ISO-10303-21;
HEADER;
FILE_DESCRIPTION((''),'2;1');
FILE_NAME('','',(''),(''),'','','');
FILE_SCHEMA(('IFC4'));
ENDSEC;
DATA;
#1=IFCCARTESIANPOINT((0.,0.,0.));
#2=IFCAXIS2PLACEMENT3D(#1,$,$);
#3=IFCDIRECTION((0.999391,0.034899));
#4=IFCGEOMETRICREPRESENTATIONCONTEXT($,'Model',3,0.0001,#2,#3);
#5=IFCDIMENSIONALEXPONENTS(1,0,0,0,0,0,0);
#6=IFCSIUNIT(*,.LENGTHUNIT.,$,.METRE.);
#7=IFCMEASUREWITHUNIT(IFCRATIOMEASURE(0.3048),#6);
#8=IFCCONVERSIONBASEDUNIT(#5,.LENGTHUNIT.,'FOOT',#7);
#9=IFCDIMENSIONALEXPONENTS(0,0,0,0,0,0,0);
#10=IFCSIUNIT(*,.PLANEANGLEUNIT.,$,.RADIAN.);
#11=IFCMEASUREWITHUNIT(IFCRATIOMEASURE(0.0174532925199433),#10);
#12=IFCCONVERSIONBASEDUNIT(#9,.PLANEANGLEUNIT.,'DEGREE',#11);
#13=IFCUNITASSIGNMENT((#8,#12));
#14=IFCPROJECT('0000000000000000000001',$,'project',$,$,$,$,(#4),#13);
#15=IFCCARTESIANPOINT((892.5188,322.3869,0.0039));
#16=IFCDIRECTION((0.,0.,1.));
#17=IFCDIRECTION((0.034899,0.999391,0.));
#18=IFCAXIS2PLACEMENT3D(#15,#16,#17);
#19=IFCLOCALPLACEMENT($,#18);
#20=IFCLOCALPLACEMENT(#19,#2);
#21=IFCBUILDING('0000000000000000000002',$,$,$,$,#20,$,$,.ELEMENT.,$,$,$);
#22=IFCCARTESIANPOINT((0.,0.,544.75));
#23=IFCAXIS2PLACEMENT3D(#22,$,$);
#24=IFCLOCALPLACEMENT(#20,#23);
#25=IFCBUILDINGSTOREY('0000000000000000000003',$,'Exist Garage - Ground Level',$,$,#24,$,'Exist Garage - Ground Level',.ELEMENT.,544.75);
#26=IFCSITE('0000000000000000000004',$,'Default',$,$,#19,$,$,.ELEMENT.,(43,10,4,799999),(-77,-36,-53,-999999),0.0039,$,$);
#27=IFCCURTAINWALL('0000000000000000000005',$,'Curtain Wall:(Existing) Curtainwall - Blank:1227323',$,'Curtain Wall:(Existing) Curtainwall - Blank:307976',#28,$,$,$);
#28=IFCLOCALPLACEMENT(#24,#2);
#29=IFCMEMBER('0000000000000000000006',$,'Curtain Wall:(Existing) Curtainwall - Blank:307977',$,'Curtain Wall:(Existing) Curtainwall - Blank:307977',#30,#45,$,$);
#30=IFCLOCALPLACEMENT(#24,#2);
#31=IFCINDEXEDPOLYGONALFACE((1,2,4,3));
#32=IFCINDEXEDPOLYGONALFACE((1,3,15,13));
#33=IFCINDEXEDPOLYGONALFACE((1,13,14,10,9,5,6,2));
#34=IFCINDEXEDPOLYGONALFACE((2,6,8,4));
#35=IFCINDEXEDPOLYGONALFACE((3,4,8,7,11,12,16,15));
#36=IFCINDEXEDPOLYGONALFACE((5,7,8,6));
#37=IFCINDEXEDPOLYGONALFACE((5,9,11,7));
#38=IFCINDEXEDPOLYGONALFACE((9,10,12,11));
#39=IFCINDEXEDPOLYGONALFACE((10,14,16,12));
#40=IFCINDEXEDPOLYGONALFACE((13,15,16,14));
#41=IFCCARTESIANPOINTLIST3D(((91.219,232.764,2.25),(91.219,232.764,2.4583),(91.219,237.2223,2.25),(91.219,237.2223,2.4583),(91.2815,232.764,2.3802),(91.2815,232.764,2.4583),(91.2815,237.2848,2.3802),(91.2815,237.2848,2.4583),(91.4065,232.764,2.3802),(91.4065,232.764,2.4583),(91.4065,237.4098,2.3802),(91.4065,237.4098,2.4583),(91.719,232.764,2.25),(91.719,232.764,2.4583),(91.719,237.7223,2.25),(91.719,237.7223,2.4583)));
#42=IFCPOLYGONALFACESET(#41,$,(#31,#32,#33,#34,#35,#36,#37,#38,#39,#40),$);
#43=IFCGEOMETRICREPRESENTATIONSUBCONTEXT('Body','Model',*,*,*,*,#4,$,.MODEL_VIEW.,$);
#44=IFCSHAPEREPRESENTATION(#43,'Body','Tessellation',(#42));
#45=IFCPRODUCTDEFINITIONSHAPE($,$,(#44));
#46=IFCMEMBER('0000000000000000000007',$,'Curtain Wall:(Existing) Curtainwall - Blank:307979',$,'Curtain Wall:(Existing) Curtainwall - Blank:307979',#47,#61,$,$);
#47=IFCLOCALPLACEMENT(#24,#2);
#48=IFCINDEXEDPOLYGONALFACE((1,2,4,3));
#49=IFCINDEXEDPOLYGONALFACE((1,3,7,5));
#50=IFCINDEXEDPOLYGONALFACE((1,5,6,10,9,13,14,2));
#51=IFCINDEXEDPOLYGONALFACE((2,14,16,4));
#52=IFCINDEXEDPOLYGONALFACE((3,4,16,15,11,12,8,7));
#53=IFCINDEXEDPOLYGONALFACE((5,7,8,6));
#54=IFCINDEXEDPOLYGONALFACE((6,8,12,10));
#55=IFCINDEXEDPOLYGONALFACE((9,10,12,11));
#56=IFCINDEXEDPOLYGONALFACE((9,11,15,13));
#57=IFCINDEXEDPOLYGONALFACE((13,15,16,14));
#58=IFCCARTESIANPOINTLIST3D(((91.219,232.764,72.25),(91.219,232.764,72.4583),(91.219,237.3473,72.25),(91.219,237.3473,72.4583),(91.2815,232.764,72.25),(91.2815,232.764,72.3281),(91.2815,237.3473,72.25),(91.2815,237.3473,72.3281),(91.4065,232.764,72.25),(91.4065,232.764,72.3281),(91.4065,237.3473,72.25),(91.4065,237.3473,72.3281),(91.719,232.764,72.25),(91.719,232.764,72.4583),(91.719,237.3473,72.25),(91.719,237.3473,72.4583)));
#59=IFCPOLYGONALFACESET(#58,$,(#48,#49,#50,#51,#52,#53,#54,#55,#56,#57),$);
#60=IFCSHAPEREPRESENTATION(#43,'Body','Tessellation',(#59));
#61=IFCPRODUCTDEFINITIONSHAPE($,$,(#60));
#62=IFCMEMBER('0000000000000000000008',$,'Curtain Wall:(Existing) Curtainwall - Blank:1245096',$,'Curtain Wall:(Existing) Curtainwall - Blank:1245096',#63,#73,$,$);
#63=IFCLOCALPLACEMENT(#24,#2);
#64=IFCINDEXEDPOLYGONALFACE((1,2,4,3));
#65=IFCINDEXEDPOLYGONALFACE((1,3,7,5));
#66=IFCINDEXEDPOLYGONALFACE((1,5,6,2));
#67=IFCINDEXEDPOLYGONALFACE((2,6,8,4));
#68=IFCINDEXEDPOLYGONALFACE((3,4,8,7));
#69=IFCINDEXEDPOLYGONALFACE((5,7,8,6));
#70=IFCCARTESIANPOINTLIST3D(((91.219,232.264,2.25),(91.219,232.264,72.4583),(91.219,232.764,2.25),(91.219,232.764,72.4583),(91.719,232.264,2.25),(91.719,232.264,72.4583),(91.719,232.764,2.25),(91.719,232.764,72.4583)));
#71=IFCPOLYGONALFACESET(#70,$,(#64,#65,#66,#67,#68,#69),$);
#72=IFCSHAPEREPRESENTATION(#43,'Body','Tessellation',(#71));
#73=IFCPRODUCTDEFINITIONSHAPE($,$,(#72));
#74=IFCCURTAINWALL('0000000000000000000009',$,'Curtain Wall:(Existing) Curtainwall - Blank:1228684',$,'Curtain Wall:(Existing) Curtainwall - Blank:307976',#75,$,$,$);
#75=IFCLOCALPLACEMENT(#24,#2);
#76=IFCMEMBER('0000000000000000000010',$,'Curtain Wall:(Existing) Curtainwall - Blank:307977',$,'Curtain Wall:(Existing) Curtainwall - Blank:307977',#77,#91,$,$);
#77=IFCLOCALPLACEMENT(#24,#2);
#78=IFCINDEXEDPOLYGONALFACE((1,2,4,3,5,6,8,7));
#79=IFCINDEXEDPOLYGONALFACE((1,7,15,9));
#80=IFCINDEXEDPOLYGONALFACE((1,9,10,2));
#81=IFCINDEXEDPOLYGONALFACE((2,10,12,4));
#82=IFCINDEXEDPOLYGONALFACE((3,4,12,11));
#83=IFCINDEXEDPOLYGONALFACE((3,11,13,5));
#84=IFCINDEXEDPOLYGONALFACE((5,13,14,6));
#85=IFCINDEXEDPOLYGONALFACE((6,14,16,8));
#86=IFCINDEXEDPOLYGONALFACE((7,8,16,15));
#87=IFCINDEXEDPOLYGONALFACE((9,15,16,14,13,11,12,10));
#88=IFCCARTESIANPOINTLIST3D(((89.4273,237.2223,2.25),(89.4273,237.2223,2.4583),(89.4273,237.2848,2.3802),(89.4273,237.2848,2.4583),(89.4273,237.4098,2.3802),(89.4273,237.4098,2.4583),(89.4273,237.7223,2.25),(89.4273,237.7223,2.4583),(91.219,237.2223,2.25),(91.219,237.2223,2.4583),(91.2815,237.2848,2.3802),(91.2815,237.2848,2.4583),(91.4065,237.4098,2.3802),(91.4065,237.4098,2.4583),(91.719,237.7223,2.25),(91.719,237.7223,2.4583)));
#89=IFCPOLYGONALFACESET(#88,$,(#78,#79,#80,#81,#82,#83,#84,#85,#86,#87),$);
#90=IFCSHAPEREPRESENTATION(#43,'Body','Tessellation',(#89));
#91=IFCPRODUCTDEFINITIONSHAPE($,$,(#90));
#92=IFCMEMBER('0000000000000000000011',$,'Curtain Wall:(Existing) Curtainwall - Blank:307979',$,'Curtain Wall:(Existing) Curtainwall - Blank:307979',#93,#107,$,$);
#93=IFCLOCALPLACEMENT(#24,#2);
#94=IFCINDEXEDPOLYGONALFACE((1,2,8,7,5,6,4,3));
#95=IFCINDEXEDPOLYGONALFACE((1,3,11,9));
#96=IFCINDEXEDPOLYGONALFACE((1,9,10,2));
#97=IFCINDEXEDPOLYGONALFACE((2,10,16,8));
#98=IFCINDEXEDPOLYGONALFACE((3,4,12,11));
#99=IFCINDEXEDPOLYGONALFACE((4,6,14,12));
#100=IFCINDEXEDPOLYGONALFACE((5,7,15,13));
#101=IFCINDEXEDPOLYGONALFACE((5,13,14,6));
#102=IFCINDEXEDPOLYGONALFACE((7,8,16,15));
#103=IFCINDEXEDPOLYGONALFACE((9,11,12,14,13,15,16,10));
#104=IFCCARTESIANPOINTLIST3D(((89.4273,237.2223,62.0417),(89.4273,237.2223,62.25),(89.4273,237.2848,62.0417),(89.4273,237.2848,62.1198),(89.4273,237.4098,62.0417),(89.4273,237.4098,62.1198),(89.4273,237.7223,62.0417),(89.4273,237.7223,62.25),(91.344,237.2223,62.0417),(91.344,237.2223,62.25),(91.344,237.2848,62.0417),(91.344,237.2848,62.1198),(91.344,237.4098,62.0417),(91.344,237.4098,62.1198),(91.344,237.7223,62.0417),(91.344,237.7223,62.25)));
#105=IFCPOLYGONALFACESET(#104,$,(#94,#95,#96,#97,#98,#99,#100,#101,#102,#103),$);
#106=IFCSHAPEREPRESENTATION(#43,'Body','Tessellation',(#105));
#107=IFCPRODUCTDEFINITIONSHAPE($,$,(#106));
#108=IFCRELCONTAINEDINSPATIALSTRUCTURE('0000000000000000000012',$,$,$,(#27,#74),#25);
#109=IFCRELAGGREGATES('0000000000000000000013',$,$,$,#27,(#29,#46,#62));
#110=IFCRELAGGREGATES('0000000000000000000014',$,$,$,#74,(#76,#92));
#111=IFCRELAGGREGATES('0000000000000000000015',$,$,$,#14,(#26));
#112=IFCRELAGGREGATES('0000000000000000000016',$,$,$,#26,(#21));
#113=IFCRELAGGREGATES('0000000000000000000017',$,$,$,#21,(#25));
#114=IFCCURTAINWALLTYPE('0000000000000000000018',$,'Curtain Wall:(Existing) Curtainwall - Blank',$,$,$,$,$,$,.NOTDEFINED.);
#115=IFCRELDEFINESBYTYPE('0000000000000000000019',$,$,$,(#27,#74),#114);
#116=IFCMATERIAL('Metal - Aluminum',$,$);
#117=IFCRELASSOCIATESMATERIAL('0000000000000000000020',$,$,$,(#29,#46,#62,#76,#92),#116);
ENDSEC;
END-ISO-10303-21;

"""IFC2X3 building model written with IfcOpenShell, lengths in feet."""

from ifc_helpers import new_model, entity, si_unit, converted_unit, direction, frame, origin, origin_2d_with_axis, place, context, subcontext, project, spatial, polyline, rectangle, outline, extrude, clip, halfspace, material, type_object, element, aggregate, save


model = new_model("IFC2X3")

# Units and contexts
model_context = context("Model", 3, precision=0.0001, world=origin(), true_north=direction((0.999391, 0.034899)))
body_context = subcontext(model_context, "Body", "Model", "MODEL_VIEW")
ifc_project = project(units=[converted_unit("LENGTHUNIT", "FOOT", entity("IfcRatioMeasure", 0.3048), si_unit("LENGTHUNIT", "METRE"), dimensions=[1, 0, 0, 0, 0, 0, 0]), converted_unit("PLANEANGLEUNIT", "DEGREE", entity("IfcRatioMeasure", 0.0174532925199433), si_unit("PLANEANGLEUNIT", "RADIAN"), dimensions=[0, 0, 0, 0, 0, 0, 0])], contexts=[model_context])

# Site, building, storey
site_placement = place(None, frame((892.5188, 322.3869, 0.0039), z_axis=(0.0, 0.0, 1.0), x_axis=(0.034899, 0.999391, 0.0)))
site = spatial("IfcSite", under=ifc_project, at=site_placement, Name="Default", CompositionType="ELEMENT", RefLatitude=(43, 10, 4, 799999), RefLongitude=(-77, -36, -53, -999999), RefElevation=0.0039)
building_placement = place(site_placement, origin())
building = spatial("IfcBuilding", under=site, at=building_placement, CompositionType="ELEMENT")
storey_placement = place(building_placement, frame((0.0, 0.0, 544.75)))
storey = spatial("IfcBuildingStorey", under=building, at=storey_placement, Name="Exist Garage - Ground Level", LongName="Exist Garage - Ground Level", CompositionType="ELEMENT", Elevation=544.75)

# Curtain walls, members
curtain_wall_type = type_object("IfcCurtainWallType", Name="Curtain Wall:(Existing) Curtainwall - Blank", PredefinedType="NOTDEFINED")
ifc_material = material(Name="Metal - Aluminum")
curtain_wall_1_placement = place(storey_placement, frame((0.0, 0.0, -544.75)))
curtain_wall_1 = element("IfcCurtainWall", 1, at=curtain_wall_1_placement, inside=storey, type_object=curtain_wall_type, Name="Curtain Wall:(Existing) Curtainwall - Blank:1227323", ObjectType="Curtain Wall:(Existing) Curtainwall - Blank:307976")
member_1_placement = place(curtain_wall_1_placement, frame((0.0, 0.0, 544.75)))
member_1 = element("IfcMember", 2, at=member_1_placement, material=ifc_material, Name="Curtain Wall:(Existing) Curtainwall - Blank:307977", ObjectType="Curtain Wall:(Existing) Curtainwall - Blank:307977", context=body_context, shape_type="Clipping", body=[
    clip(extrude(outline(polyline([(-0.0716, -0.3125), (0.1367, -0.3125), (0.1367, 0.1875), (-0.0716, 0.1875), (-0.0716, 0.125), (0.0065, 0.125), (0.0065, 0.0), (-0.0716, 0.0), (-0.0716, -0.3125)])), frame((91.4065, 232.764, 2.3867), z_axis=(0.0, 1.0, 0.0), x_axis=(0.0, 0.0, -1.0)), (0.0, 0.0, 1.0), 4.9583), halfspace(frame((91.344, 237.3473, 1.25), z_axis=(-0.707107, 0.707107, 0.0), x_axis=(0.707107, 0.707107, 0.0)), False)),
])
member_2_placement = place(curtain_wall_1_placement, frame((0.0, 0.0, 544.75)))
member_2 = element("IfcMember", 3, at=member_2_placement, material=ifc_material, Name="Curtain Wall:(Existing) Curtainwall - Blank:307979", ObjectType="Curtain Wall:(Existing) Curtainwall - Blank:307979", context=body_context, shape_type="SweptSolid", body=[
    extrude(outline(polyline([(-0.1367, -0.1875), (0.0716, -0.1875), (0.0716, -0.125), (-0.0065, -0.125), (-0.0065, 0.0), (0.0716, 0.0), (0.0716, 0.3125), (-0.1367, 0.3125), (-0.1367, -0.1875)])), frame((91.4065, 237.3473, 72.3216), z_axis=(0.0, -1.0, 0.0), x_axis=(0.0, 0.0, -1.0)), (0.0, 0.0, 1.0), 4.5833),
])
member_3_placement = place(curtain_wall_1_placement, frame((0.0, 0.0, 544.75)))
member_3 = element("IfcMember", 4, at=member_3_placement, material=ifc_material, Name="Curtain Wall:(Existing) Curtainwall - Blank:1245096", ObjectType="Curtain Wall:(Existing) Curtainwall - Blank:1245096", context=body_context, shape_type="SweptSolid", body=[
    extrude(rectangle(XDim=0.5, YDim=0.5, at=origin_2d_with_axis()), frame((91.469, 232.514, 72.4583), z_axis=(0.0, 0.0, -1.0), x_axis=(-1.0, 0.0, 0.0)), (0.0, 0.0, 1.0), 70.2083),
])
aggregate(curtain_wall_1, [member_1, member_2, member_3])
curtain_wall_2_placement = place(storey_placement, frame((0.0, 0.0, -544.75)))
curtain_wall_2 = element("IfcCurtainWall", 5, at=curtain_wall_2_placement, inside=storey, type_object=curtain_wall_type, Name="Curtain Wall:(Existing) Curtainwall - Blank:1228684", ObjectType="Curtain Wall:(Existing) Curtainwall - Blank:307976")
member_4_placement = place(curtain_wall_2_placement, frame((0.0, 0.0, 544.75)))
member_4 = element("IfcMember", 6, at=member_4_placement, material=ifc_material, Name="Curtain Wall:(Existing) Curtainwall - Blank:307977", ObjectType="Curtain Wall:(Existing) Curtainwall - Blank:307977", context=body_context, shape_type="Clipping", body=[
    clip(extrude(outline(polyline([(-0.0716, -0.3125), (0.1367, -0.3125), (0.1367, 0.1875), (-0.0716, 0.1875), (-0.0716, 0.125), (0.0065, 0.125), (0.0065, 0.0), (-0.0716, 0.0), (-0.0716, -0.3125)])), frame((91.719, 237.4098, 2.3867), z_axis=(-1.0, 0.0, 0.0), x_axis=(0.0, 0.0, -1.0)), (0.0, 0.0, 1.0), 2.2917), halfspace(frame((91.344, 237.3473, 1.25), z_axis=(0.707107, -0.707107, 0.0), x_axis=(0.707107, 0.707107, 0.0)), False)),
])
member_5_placement = place(curtain_wall_2_placement, frame((0.0, 0.0, 544.75)))
member_5 = element("IfcMember", 7, at=member_5_placement, material=ifc_material, Name="Curtain Wall:(Existing) Curtainwall - Blank:307979", ObjectType="Curtain Wall:(Existing) Curtainwall - Blank:307979", context=body_context, shape_type="SweptSolid", body=[
    extrude(outline(polyline([(-0.1367, -0.1875), (0.0716, -0.1875), (0.0716, -0.125), (-0.0065, -0.125), (-0.0065, 0.0), (0.0716, 0.0), (0.0716, 0.3125), (-0.1367, 0.3125), (-0.1367, -0.1875)])), frame((89.4273, 237.4098, 62.1133), z_axis=(1.0, 0.0, 0.0), x_axis=(0.0, 0.0, -1.0)), (0.0, 0.0, 1.0), 1.9167),
])
aggregate(curtain_wall_2, [member_4, member_5])

save(model, "model.ifc")
